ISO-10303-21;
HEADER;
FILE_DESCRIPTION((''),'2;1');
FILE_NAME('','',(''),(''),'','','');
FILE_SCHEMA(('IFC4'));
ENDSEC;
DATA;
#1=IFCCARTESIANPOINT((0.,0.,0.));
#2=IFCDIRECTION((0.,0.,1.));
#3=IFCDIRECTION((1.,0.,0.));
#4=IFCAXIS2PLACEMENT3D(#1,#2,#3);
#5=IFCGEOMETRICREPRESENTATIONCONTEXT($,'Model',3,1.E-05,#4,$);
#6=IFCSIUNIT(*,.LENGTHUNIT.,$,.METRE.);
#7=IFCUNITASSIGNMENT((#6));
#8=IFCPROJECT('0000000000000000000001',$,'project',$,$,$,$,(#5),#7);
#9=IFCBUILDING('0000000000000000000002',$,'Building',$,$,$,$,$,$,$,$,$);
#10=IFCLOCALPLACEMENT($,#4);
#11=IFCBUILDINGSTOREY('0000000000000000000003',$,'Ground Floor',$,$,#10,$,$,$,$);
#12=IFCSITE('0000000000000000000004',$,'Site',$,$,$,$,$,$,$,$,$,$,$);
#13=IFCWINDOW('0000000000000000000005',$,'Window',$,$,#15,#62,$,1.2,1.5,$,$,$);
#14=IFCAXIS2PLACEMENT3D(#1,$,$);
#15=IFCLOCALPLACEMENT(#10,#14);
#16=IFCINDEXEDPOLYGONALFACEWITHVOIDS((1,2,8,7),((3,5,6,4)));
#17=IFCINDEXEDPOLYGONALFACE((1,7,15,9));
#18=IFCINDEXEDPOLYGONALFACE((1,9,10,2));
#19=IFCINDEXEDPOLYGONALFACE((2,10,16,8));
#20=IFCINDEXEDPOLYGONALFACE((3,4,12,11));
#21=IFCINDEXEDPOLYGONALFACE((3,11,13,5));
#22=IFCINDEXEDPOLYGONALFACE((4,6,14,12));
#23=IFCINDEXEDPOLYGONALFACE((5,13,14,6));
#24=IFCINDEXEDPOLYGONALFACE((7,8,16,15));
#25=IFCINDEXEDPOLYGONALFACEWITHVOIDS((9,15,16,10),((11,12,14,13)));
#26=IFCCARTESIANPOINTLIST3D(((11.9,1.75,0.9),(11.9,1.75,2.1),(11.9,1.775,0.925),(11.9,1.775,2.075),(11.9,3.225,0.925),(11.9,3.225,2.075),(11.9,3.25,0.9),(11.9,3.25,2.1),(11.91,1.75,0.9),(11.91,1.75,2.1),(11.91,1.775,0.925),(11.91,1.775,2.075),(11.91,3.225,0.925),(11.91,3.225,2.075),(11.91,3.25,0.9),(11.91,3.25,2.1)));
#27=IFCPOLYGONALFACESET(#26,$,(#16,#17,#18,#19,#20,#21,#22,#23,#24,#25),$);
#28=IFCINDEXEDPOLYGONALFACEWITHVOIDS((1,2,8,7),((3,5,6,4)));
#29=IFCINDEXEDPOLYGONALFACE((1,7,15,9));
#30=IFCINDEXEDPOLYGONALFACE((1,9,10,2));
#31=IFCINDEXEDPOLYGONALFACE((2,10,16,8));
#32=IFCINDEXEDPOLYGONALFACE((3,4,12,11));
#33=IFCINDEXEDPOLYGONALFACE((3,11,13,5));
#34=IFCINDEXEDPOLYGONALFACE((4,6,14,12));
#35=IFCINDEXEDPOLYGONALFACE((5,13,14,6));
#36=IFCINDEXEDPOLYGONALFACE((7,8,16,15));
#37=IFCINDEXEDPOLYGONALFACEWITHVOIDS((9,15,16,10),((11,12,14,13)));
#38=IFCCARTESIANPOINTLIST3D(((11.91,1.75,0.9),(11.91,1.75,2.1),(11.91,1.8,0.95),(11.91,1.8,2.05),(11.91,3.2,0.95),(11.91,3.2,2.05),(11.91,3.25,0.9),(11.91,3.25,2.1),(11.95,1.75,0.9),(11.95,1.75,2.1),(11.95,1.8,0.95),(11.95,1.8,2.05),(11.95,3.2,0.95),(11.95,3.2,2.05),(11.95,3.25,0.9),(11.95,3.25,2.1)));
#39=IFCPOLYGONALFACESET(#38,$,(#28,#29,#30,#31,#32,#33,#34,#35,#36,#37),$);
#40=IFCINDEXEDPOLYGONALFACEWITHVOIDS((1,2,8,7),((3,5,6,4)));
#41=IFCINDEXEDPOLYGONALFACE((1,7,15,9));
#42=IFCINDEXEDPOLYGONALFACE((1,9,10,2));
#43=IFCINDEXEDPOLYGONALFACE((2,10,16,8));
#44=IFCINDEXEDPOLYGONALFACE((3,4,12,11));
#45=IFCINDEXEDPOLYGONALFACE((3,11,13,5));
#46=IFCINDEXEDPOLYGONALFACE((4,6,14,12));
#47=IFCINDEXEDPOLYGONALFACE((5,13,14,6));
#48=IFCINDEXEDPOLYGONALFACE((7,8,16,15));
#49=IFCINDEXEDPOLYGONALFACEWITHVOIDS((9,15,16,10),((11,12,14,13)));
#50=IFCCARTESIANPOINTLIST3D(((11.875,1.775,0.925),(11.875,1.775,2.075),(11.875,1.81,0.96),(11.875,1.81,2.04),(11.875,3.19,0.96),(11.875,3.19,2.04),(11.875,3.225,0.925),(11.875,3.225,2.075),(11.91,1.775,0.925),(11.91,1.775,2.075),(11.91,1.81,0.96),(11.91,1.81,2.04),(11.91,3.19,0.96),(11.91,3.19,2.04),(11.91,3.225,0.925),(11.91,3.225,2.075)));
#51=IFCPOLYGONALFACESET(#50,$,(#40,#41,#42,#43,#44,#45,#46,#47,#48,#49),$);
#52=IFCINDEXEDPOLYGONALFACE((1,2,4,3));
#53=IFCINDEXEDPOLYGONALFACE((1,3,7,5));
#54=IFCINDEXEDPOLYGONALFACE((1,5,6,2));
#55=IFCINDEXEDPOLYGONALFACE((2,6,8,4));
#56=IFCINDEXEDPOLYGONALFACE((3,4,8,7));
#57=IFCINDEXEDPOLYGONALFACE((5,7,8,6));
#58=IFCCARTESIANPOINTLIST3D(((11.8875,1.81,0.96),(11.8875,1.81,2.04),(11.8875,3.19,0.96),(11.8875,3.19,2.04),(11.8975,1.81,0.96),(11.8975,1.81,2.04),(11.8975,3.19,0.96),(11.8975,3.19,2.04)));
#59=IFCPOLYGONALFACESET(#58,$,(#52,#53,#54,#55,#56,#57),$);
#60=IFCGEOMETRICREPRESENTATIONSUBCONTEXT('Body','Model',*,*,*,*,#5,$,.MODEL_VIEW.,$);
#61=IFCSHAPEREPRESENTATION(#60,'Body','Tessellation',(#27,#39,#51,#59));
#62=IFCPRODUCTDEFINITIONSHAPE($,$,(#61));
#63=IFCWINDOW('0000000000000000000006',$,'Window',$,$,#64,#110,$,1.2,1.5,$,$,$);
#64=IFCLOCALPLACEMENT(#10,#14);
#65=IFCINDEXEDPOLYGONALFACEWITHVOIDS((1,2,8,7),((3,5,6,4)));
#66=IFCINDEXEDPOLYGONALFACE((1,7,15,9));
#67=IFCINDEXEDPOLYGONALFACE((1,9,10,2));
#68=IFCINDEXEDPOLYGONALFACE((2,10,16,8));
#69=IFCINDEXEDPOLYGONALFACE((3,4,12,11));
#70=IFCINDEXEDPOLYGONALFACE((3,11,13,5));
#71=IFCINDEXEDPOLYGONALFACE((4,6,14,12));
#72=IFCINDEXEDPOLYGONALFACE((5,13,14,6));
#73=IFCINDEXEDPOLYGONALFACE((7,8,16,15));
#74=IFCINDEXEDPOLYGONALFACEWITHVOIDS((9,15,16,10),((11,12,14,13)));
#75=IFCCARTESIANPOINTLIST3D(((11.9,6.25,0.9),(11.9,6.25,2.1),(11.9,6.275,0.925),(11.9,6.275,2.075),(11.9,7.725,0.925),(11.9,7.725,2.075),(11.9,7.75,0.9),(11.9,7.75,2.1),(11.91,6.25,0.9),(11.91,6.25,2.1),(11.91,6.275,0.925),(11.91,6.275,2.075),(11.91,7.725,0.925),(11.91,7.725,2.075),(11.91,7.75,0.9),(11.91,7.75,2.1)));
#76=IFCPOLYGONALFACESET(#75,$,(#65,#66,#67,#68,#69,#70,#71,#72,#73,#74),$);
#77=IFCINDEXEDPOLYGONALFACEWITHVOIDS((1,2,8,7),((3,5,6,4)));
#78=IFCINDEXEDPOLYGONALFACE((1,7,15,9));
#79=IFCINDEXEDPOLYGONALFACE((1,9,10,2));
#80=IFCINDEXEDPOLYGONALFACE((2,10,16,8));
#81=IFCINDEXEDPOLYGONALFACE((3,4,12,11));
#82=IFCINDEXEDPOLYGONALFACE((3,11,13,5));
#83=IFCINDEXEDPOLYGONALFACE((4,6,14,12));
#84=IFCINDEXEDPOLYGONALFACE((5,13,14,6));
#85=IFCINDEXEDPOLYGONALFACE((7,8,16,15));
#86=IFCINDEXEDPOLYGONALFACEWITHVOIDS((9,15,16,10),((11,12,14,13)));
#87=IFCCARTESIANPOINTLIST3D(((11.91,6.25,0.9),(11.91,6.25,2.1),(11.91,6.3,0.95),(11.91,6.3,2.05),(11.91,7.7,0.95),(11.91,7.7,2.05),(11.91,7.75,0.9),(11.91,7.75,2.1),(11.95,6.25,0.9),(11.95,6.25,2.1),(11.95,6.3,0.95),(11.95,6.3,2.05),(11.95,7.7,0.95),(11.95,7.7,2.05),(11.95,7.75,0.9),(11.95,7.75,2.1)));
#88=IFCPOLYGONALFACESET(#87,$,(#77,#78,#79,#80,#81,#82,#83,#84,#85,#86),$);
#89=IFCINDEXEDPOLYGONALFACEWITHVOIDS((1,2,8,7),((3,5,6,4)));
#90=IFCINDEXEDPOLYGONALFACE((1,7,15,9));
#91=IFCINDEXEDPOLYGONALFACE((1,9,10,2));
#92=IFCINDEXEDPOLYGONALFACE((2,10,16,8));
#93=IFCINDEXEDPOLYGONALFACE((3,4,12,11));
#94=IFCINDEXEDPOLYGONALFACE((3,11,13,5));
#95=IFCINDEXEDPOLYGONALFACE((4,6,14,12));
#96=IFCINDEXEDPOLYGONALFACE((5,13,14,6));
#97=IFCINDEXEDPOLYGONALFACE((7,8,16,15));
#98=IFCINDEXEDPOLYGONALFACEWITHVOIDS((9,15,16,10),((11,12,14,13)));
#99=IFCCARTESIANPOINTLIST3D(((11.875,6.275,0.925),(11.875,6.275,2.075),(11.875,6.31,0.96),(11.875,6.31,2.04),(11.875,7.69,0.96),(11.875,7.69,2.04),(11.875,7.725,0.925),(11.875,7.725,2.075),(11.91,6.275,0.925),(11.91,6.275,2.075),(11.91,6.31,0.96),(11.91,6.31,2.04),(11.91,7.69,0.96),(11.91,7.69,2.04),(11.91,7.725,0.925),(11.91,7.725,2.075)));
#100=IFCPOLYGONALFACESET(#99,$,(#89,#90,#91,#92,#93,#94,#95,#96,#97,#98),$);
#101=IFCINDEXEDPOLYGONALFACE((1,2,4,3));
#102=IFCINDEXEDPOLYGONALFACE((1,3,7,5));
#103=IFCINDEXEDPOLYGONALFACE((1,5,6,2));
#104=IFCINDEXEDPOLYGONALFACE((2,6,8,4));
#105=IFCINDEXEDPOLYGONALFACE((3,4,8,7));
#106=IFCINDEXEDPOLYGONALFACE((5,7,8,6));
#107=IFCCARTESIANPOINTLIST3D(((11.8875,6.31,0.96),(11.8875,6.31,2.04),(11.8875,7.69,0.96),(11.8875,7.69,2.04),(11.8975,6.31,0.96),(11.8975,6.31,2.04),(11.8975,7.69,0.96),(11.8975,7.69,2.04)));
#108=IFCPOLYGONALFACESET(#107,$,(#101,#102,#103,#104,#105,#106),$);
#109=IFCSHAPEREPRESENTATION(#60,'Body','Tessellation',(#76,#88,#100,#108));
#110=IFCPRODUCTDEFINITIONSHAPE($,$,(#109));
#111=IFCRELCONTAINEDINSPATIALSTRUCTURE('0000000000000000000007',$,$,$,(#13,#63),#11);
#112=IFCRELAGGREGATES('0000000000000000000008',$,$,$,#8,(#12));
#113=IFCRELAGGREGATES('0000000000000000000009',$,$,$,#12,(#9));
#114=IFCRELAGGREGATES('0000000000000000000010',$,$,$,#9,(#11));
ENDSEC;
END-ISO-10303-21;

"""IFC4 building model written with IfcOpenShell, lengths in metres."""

from ifc_helpers import new_model, si_unit, frame, origin_with_axes, place, context, subcontext, project, spatial, line, indexed_curve, outline, extrude, element, save


model = new_model("IFC4")

# Units and contexts
model_context = context("Model", 3, precision=1e-05, world=origin_with_axes())
body_context = subcontext(model_context, "Body", "Model", "MODEL_VIEW")
ifc_project = project(units=[si_unit("LENGTHUNIT", "METRE")], contexts=[model_context])

# Site, building, storey
site = spatial("IfcSite", under=ifc_project, Name="Site")
building = spatial("IfcBuilding", under=site, Name="Building")
storey_placement = place(None, origin_with_axes())
storey = spatial("IfcBuildingStorey", under=building, at=storey_placement, Name="Ground Floor")

# Windows
for number, where, z_axis, x_axis, name in (
    (1, (12.0, 1.75, 0.9), (0.0, 0.0, 1.0), (0.0, 1.0, 0.0), "Window"),
    (2, (12.0, 6.25, 0.9), (0.0, 0.0, 1.0), (0.0, 1.0, 0.0), "Window"),
):
    element("IfcWindow", number, at=place(storey_placement, frame(where, z_axis=z_axis, x_axis=x_axis)), inside=storey, Name=name, OverallHeight=1.2, OverallWidth=1.5, context=body_context, shape_type="SweptSolid", body=[
        extrude(outline(indexed_curve([(0.0, 0.0), (1.5, 0.0), (1.5, 1.2), (0.0, 1.2)], segments=[line(1, 2, 3, 4, 1)]), holes=[indexed_curve([(0.025, 0.025), (1.475, 0.025), (1.475, 1.175), (0.025, 1.175)], segments=[line(1, 2, 3, 4, 1)])]), frame((0.0, 0.09, 0.0), z_axis=(0.0, -1.0, 0.0), x_axis=(1.0, 0.0, 0.0)), (0.0, 0.0, -1.0), 0.01),
        extrude(outline(indexed_curve([(0.0, 0.0), (1.5, 0.0), (1.5, 1.2), (0.0, 1.2)], segments=[line(1, 2, 3, 4, 1)]), holes=[indexed_curve([(0.05, 0.05), (1.45, 0.05), (1.45, 1.15), (0.05, 1.15)], segments=[line(1, 2, 3, 4, 1)])]), frame((0.0, 0.05, 0.0), z_axis=(0.0, -1.0, 0.0), x_axis=(1.0, 0.0, 0.0)), (0.0, 0.0, -1.0), 0.04),
        extrude(outline(indexed_curve([(0.0, 0.0), (1.45, 0.0), (1.45, 1.15), (0.0, 1.15)], segments=[line(1, 2, 3, 4, 1)]), holes=[indexed_curve([(0.035, 0.035), (1.415, 0.035), (1.415, 1.115), (0.035, 1.115)], segments=[line(1, 2, 3, 4, 1)])]), frame((0.025, 0.09, 0.025), z_axis=(0.0, -1.0, 0.0), x_axis=(1.0, 0.0, 0.0)), (0.0, 0.0, -1.0), 0.035),
        extrude(outline(indexed_curve([(0.035, 0.035), (1.415, 0.035), (1.415, 1.115), (0.035, 1.115)], segments=[line(1, 2, 3, 4, 1)])), frame((0.025, 0.1025, 0.025), z_axis=(0.0, -1.0, 0.0), x_axis=(1.0, 0.0, 0.0)), (0.0, 0.0, -1.0), 0.01),
    ])

save(model, "model.ifc")
